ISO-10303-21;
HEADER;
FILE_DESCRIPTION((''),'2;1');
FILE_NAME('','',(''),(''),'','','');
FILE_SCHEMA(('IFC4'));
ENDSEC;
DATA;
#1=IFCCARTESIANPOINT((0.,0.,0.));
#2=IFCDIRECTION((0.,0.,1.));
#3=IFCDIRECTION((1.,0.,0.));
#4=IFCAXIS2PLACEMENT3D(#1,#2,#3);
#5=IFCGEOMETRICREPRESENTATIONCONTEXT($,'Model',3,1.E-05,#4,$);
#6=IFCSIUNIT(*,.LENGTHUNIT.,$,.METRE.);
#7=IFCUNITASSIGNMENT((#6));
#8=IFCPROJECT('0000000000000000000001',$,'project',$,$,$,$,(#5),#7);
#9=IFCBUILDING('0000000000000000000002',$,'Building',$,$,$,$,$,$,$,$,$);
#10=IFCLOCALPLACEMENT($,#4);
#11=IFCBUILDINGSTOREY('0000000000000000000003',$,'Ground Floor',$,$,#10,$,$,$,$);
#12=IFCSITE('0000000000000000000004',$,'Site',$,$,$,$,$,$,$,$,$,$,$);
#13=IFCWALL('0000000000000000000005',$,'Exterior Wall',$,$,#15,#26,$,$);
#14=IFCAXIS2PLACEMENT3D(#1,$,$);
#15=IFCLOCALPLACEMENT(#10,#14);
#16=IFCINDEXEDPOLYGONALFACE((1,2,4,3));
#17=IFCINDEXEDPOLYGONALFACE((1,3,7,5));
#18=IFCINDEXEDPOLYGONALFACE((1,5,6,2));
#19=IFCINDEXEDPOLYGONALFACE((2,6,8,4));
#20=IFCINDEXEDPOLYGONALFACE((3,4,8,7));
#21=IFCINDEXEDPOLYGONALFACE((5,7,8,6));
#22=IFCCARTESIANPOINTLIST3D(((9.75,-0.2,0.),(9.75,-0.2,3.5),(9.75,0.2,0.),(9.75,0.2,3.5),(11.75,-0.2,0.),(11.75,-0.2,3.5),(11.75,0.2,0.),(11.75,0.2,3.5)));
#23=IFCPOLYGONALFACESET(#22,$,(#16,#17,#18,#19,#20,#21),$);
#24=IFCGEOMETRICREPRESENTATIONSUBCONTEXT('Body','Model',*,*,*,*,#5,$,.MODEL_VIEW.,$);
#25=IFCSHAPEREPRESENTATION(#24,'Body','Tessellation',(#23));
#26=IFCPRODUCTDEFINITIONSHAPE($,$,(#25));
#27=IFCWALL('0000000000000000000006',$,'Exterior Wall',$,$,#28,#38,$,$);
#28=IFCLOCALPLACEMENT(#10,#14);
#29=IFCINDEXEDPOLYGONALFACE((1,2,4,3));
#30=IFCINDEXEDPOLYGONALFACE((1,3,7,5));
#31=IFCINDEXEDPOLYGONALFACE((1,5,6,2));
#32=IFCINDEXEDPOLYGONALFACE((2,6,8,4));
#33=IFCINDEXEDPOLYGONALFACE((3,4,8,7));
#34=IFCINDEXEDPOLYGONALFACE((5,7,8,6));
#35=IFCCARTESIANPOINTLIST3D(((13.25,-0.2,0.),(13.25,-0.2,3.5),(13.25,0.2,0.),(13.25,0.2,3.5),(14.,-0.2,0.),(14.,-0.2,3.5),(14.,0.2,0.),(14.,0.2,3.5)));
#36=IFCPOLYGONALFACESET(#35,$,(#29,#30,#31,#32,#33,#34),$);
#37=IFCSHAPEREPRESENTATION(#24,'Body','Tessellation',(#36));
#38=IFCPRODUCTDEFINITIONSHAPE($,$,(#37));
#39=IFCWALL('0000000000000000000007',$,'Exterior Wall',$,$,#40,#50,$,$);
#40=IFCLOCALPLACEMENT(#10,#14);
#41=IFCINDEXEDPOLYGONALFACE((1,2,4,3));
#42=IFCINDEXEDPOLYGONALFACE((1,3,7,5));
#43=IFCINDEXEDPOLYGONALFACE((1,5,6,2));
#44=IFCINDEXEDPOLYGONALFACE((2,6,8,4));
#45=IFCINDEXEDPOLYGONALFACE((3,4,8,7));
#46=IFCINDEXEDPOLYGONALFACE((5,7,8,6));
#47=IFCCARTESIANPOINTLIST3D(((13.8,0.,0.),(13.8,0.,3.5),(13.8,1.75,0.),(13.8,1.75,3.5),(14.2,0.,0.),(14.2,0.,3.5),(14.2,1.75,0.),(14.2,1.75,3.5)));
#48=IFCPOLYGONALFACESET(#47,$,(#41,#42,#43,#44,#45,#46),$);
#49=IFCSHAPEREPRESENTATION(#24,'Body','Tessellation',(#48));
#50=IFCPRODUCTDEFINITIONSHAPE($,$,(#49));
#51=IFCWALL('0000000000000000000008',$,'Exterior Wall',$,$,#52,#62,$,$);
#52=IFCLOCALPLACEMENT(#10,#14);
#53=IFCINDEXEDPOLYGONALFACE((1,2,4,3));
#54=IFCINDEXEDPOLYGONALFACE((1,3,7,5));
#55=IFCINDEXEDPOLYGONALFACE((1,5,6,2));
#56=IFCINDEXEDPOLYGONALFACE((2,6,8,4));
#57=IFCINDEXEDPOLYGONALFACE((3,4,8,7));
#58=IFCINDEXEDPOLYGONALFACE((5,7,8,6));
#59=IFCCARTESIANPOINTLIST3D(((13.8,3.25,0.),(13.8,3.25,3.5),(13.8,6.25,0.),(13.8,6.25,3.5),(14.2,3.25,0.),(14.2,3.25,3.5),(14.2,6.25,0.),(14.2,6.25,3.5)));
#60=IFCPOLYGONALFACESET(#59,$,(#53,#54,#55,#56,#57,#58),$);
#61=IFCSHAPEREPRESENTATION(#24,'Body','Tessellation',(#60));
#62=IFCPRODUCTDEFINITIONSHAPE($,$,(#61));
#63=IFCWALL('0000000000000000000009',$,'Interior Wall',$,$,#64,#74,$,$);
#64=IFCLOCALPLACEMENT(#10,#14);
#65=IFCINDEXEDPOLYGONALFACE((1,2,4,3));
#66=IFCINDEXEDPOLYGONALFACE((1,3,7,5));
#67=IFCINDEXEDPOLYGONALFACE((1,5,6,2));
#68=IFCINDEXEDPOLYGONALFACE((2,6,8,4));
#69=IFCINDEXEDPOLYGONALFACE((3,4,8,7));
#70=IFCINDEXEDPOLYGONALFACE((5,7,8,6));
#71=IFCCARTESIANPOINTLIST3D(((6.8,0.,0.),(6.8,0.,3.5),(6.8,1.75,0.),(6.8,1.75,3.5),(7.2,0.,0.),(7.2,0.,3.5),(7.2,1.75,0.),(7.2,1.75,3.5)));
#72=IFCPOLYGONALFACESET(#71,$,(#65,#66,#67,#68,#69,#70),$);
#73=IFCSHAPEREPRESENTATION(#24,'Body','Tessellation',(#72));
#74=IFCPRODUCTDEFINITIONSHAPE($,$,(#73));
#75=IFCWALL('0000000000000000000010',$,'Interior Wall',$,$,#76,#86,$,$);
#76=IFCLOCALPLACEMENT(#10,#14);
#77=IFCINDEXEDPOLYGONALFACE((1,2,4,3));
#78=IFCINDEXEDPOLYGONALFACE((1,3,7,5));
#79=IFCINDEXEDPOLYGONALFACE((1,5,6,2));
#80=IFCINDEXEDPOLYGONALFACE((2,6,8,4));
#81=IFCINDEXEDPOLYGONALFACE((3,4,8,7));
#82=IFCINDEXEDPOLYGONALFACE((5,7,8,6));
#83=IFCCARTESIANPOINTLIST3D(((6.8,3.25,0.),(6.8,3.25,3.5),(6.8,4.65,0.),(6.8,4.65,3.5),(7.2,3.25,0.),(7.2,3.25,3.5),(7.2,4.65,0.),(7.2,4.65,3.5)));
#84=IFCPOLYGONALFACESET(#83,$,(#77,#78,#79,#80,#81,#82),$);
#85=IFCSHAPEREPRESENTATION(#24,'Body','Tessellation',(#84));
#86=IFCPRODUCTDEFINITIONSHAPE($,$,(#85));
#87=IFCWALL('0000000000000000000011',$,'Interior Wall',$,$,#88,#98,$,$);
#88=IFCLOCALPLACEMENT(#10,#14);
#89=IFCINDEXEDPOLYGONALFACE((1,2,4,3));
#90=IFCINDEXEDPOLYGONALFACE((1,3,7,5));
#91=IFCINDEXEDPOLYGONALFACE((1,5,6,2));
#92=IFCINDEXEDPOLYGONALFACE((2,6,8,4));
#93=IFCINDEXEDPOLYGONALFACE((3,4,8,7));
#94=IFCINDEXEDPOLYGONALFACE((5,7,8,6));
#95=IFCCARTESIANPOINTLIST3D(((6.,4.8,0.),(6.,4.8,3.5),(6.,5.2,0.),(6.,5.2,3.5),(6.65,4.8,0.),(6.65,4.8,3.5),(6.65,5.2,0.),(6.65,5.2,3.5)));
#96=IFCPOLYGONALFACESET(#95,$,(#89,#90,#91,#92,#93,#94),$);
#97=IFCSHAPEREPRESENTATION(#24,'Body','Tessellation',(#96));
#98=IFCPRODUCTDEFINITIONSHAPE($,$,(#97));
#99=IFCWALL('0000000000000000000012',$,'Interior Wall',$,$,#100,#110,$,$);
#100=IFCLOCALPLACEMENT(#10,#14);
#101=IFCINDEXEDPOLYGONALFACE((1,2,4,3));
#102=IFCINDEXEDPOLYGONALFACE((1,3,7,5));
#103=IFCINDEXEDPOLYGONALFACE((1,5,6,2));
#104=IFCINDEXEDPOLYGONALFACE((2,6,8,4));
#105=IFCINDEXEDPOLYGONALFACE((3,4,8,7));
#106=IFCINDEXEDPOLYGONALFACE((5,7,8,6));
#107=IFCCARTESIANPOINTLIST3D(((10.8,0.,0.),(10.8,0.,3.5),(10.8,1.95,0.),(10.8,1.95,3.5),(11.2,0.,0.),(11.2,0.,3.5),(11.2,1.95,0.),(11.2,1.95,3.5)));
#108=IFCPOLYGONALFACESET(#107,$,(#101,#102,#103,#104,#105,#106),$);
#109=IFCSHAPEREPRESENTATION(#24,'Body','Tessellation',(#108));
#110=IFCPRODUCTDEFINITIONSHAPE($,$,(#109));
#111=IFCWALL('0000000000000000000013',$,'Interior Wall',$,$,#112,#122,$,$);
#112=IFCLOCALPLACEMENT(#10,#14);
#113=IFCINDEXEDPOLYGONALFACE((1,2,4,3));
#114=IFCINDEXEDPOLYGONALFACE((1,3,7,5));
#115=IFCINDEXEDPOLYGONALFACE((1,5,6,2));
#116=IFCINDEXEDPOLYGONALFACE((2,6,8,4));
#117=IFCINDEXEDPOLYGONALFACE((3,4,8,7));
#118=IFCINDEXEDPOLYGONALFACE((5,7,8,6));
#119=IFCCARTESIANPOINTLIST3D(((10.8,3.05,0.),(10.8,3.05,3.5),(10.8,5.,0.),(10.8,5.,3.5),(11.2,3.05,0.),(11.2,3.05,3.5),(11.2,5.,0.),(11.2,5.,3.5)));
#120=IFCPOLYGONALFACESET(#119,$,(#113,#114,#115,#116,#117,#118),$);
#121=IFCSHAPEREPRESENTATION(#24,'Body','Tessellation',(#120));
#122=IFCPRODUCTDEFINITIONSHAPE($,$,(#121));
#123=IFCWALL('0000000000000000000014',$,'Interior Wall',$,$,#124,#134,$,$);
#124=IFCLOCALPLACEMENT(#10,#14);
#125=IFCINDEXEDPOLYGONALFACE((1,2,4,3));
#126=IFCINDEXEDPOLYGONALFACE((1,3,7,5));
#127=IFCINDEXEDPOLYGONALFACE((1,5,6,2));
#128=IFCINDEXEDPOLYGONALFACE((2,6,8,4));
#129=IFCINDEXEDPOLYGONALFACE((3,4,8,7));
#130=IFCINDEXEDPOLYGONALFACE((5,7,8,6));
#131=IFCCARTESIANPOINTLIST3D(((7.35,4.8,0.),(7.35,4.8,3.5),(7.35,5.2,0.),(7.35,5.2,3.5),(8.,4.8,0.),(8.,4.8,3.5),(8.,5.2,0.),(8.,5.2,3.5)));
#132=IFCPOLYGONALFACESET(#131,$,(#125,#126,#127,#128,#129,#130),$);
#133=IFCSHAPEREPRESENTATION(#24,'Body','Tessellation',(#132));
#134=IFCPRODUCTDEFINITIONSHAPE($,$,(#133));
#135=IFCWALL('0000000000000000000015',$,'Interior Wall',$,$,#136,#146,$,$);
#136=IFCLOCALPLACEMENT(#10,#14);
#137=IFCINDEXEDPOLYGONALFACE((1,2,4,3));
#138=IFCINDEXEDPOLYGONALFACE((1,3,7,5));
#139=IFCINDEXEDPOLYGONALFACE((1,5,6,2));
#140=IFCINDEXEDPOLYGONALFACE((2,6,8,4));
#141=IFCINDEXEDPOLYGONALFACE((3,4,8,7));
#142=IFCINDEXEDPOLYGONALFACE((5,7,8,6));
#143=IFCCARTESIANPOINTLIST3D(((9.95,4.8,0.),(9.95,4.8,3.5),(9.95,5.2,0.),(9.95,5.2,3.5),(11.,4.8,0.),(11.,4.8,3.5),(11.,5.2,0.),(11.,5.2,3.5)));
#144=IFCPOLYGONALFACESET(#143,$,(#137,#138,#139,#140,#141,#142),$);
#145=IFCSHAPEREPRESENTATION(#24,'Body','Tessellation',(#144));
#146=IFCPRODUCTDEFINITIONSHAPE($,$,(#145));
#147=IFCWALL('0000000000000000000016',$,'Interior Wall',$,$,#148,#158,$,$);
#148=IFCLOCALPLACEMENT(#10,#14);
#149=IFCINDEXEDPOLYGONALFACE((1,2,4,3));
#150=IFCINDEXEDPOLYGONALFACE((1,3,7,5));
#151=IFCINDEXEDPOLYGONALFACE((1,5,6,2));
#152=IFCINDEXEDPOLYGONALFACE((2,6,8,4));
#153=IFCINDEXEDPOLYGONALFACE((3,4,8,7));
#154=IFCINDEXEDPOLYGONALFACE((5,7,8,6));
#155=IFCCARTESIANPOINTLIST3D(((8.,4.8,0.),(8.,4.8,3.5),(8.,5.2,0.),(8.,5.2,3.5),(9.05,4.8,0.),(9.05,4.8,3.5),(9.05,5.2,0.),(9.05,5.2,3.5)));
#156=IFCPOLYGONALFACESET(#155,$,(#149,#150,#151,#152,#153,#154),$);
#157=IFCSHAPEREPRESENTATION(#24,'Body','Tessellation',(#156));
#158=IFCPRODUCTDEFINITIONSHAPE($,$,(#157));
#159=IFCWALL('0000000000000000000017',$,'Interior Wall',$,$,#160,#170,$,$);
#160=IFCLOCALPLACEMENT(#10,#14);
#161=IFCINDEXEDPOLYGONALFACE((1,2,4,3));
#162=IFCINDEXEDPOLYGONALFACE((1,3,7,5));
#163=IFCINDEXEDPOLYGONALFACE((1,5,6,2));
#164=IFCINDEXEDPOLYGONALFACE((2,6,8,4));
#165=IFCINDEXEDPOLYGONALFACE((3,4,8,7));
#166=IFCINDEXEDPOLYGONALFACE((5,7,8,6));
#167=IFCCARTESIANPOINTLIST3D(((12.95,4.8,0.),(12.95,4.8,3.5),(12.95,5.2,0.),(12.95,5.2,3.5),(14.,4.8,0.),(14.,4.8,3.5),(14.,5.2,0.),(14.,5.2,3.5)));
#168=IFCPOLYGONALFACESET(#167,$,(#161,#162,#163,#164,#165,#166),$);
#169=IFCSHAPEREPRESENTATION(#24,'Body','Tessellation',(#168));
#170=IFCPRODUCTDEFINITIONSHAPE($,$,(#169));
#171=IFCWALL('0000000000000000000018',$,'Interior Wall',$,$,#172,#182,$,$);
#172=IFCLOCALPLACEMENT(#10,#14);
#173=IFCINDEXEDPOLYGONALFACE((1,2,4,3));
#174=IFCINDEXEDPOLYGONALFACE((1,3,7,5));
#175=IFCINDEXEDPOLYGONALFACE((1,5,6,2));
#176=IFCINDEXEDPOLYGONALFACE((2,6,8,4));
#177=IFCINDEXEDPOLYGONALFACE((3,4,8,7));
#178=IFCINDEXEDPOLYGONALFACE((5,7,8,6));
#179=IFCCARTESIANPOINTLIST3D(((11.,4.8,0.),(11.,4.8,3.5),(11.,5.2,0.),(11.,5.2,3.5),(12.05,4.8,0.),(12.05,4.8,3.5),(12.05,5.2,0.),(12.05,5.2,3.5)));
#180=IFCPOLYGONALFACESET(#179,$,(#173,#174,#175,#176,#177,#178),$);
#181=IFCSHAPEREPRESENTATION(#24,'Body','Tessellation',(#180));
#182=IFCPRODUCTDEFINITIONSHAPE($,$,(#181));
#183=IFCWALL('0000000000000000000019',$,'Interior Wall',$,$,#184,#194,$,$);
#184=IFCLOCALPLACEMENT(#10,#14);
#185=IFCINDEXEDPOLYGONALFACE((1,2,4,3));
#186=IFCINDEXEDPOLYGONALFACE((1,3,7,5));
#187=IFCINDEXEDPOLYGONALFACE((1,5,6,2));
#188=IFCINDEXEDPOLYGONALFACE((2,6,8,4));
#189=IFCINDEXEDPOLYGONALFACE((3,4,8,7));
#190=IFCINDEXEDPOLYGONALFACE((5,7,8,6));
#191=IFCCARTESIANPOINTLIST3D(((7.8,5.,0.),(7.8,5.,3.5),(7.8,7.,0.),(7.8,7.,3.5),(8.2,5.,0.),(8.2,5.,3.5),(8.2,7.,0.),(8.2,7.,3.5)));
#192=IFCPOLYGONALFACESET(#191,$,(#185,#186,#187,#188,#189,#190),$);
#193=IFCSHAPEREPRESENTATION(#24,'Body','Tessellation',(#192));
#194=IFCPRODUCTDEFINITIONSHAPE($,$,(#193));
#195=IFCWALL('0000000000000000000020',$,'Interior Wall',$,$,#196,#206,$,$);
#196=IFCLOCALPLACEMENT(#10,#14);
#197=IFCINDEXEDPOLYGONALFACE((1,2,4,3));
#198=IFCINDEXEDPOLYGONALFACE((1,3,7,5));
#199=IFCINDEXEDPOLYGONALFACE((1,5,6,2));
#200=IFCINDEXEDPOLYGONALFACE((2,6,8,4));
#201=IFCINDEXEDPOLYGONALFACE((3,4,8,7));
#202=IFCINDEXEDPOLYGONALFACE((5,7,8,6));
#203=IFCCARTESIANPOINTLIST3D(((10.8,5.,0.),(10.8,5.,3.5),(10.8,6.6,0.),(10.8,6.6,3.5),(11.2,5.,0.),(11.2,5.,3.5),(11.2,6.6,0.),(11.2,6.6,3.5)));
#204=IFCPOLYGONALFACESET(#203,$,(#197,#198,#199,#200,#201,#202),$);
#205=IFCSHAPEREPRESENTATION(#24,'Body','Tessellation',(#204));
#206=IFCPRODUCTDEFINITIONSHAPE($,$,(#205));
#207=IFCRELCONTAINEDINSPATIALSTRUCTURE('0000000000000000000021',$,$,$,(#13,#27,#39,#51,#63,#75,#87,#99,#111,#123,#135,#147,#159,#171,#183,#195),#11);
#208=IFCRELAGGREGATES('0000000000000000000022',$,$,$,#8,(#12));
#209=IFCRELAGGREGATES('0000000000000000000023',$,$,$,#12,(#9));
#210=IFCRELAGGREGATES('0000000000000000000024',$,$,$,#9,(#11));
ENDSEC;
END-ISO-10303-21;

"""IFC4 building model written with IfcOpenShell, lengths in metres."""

from ifc_helpers import new_model, si_unit, frame, origin_with_axes, place, context, subcontext, project, spatial, indexed_curve, outline, extrude, element, save


model = new_model("IFC4")

# Units and contexts
model_context = context("Model", 3, precision=1e-05, world=origin_with_axes())
body_context = subcontext(model_context, "Body", "Model", "MODEL_VIEW")
ifc_project = project(units=[si_unit("LENGTHUNIT", "METRE")], contexts=[model_context])

# Site, building, storey
site = spatial("IfcSite", under=ifc_project, Name="Site")
building = spatial("IfcBuilding", under=site, Name="Building")
storey_placement = place(None, origin_with_axes())
storey = spatial("IfcBuildingStorey", under=building, at=storey_placement, Name="Ground Floor")

# Walls
wall_1_placement = place(storey_placement, frame((9.75, 0.0, 0.0), z_axis=(0.0, 0.0, 1.0), x_axis=(1.0, 0.0, 0.0)))
element("IfcWall", 1, at=wall_1_placement, inside=storey, Name="Exterior Wall", context=body_context, shape_type="SweptSolid", body=[
    extrude(outline(indexed_curve([(0.0, 0.0), (0.0, 0.4), (2.0, 0.4), (2.0, 0.0), (0.0, 0.0)], self_intersect=False)), frame((0.0, -0.2, 0.0), z_axis=(0.0, 0.0, 1.0), x_axis=(1.0, 0.0, 0.0)), (0.0, 0.0, 1.0), 3.5),
])
wall_2_placement = place(storey_placement, frame((13.25, 0.0, 0.0), z_axis=(0.0, 0.0, 1.0), x_axis=(1.0, 0.0, 0.0)))
element("IfcWall", 2, at=wall_2_placement, inside=storey, Name="Exterior Wall", context=body_context, shape_type="SweptSolid", body=[
    extrude(outline(indexed_curve([(0.0, 0.0), (0.0, 0.4), (0.75, 0.4), (0.75, 0.0), (0.0, 0.0)], self_intersect=False)), frame((0.0, -0.2, 0.0), z_axis=(0.0, 0.0, 1.0), x_axis=(1.0, 0.0, 0.0)), (0.0, 0.0, 1.0), 3.5),
])
wall_3_placement = place(storey_placement, frame((14.0, 0.0, 0.0), z_axis=(0.0, 0.0, 1.0), x_axis=(0.0, 1.0, 0.0)))
element("IfcWall", 3, at=wall_3_placement, inside=storey, Name="Exterior Wall", context=body_context, shape_type="SweptSolid", body=[
    extrude(outline(indexed_curve([(0.0, 0.0), (0.0, 0.4), (1.75, 0.4), (1.75, 0.0), (0.0, 0.0)], self_intersect=False)), frame((0.0, -0.2, 0.0), z_axis=(0.0, 0.0, 1.0), x_axis=(1.0, 0.0, 0.0)), (0.0, 0.0, 1.0), 3.5),
])
wall_4_placement = place(storey_placement, frame((14.0, 3.25, 0.0), z_axis=(0.0, 0.0, 1.0), x_axis=(0.0, 1.0, 0.0)))
element("IfcWall", 4, at=wall_4_placement, inside=storey, Name="Exterior Wall", context=body_context, shape_type="SweptSolid", body=[
    extrude(outline(indexed_curve([(0.0, 0.0), (0.0, 0.4), (3.0, 0.4), (3.0, 0.0), (0.0, 0.0)], self_intersect=False)), frame((0.0, -0.2, 0.0), z_axis=(0.0, 0.0, 1.0), x_axis=(1.0, 0.0, 0.0)), (0.0, 0.0, 1.0), 3.5),
])
wall_5_placement = place(storey_placement, frame((7.0, 0.0, 0.0), z_axis=(0.0, 0.0, 1.0), x_axis=(0.0, 1.0, 0.0)))
element("IfcWall", 5, at=wall_5_placement, inside=storey, Name="Interior Wall", context=body_context, shape_type="SweptSolid", body=[
    extrude(outline(indexed_curve([(0.0, 0.0), (0.0, 0.4), (1.75, 0.4), (1.75, 0.0), (0.0, 0.0)], self_intersect=False)), frame((0.0, -0.2, 0.0), z_axis=(0.0, 0.0, 1.0), x_axis=(1.0, 0.0, 0.0)), (0.0, 0.0, 1.0), 3.5),
])
wall_6_placement = place(storey_placement, frame((7.0, 3.25, 0.0), z_axis=(0.0, 0.0, 1.0), x_axis=(0.0, 1.0, 0.0)))
element("IfcWall", 6, at=wall_6_placement, inside=storey, Name="Interior Wall", context=body_context, shape_type="SweptSolid", body=[
    extrude(outline(indexed_curve([(0.0, 0.0), (0.0, 0.4), (1.4, 0.4), (1.4, 0.0), (0.0, 0.0)], self_intersect=False)), frame((0.0, -0.2, 0.0), z_axis=(0.0, 0.0, 1.0), x_axis=(1.0, 0.0, 0.0)), (0.0, 0.0, 1.0), 3.5),
])
wall_7_placement = place(storey_placement, frame((6.65, 5.0, 0.0), z_axis=(0.0, 0.0, 1.0), x_axis=(-1.0, 0.0, 0.0)))
element("IfcWall", 7, at=wall_7_placement, inside=storey, Name="Interior Wall", context=body_context, shape_type="SweptSolid", body=[
    extrude(outline(indexed_curve([(0.0, 0.0), (0.0, 0.4), (0.65, 0.4), (0.65, 0.0), (0.0, 0.0)], self_intersect=False)), frame((0.0, -0.2, 0.0), z_axis=(0.0, 0.0, 1.0), x_axis=(1.0, 0.0, 0.0)), (0.0, 0.0, 1.0), 3.5),
])
wall_8_placement = place(storey_placement, frame((11.0, 0.0, 0.0), z_axis=(0.0, 0.0, 1.0), x_axis=(0.0, 1.0, 0.0)))
element("IfcWall", 8, at=wall_8_placement, inside=storey, Name="Interior Wall", context=body_context, shape_type="SweptSolid", body=[
    extrude(outline(indexed_curve([(0.0, 0.0), (0.0, 0.4), (1.95, 0.4), (1.95, 0.0), (0.0, 0.0)], self_intersect=False)), frame((0.0, -0.2, 0.0), z_axis=(0.0, 0.0, 1.0), x_axis=(1.0, 0.0, 0.0)), (0.0, 0.0, 1.0), 3.5),
])
wall_9_placement = place(storey_placement, frame((11.0, 3.05, 0.0), z_axis=(0.0, 0.0, 1.0), x_axis=(0.0, 1.0, 0.0)))
element("IfcWall", 9, at=wall_9_placement, inside=storey, Name="Interior Wall", context=body_context, shape_type="SweptSolid", body=[
    extrude(outline(indexed_curve([(0.0, 0.0), (0.0, 0.4), (1.95, 0.4), (1.95, 0.0), (0.0, 0.0)], self_intersect=False)), frame((0.0, -0.2, 0.0), z_axis=(0.0, 0.0, 1.0), x_axis=(1.0, 0.0, 0.0)), (0.0, 0.0, 1.0), 3.5),
])
wall_10_placement = place(storey_placement, frame((8.0, 5.0, 0.0), z_axis=(0.0, 0.0, 1.0), x_axis=(-1.0, 0.0, 0.0)))
element("IfcWall", 10, at=wall_10_placement, inside=storey, Name="Interior Wall", context=body_context, shape_type="SweptSolid", body=[
    extrude(outline(indexed_curve([(0.0, 0.0), (0.0, 0.4), (0.65, 0.4), (0.65, 0.0), (0.0, 0.0)], self_intersect=False)), frame((0.0, -0.2, 0.0), z_axis=(0.0, 0.0, 1.0), x_axis=(1.0, 0.0, 0.0)), (0.0, 0.0, 1.0), 3.5),
])
for number, where, z_axis, x_axis, name in (
    (11, (11.0, 5.0, 0.0), (0.0, 0.0, 1.0), (-1.0, 0.0, 0.0), "Interior Wall"),
    (12, (9.05, 5.0, 0.0), (0.0, 0.0, 1.0), (-1.0, 0.0, 0.0), "Interior Wall"),
    (13, (14.0, 5.0, 0.0), (0.0, 0.0, 1.0), (-1.0, 0.0, 0.0), "Interior Wall"),
    (14, (12.05, 5.0, 0.0), (0.0, 0.0, 1.0), (-1.0, 0.0, 0.0), "Interior Wall"),
):
    element("IfcWall", number, at=place(storey_placement, frame(where, z_axis=z_axis, x_axis=x_axis)), inside=storey, Name=name, context=body_context, shape_type="SweptSolid", body=[
        extrude(outline(indexed_curve([(0.0, 0.0), (0.0, 0.4), (1.05, 0.4), (1.05, 0.0), (0.0, 0.0)], self_intersect=False)), frame((0.0, -0.2, 0.0), z_axis=(0.0, 0.0, 1.0), x_axis=(1.0, 0.0, 0.0)), (0.0, 0.0, 1.0), 3.5),
    ])
wall_11_placement = place(storey_placement, frame((8.0, 5.0, 0.0), z_axis=(0.0, 0.0, 1.0), x_axis=(0.0, 1.0, 0.0)))
element("IfcWall", 15, at=wall_11_placement, inside=storey, Name="Interior Wall", context=body_context, shape_type="SweptSolid", body=[
    extrude(outline(indexed_curve([(0.0, 0.0), (0.0, 0.4), (2.0, 0.4), (2.0, 0.0), (0.0, 0.0)], self_intersect=False)), frame((0.0, -0.2, 0.0), z_axis=(0.0, 0.0, 1.0), x_axis=(1.0, 0.0, 0.0)), (0.0, 0.0, 1.0), 3.5),
])
wall_12_placement = place(storey_placement, frame((11.0, 5.0, 0.0), z_axis=(0.0, 0.0, 1.0), x_axis=(0.0, 1.0, 0.0)))
element("IfcWall", 16, at=wall_12_placement, inside=storey, Name="Interior Wall", context=body_context, shape_type="SweptSolid", body=[
    extrude(outline(indexed_curve([(0.0, 0.0), (0.0, 0.4), (1.6, 0.4), (1.6, 0.0), (0.0, 0.0)], self_intersect=False)), frame((0.0, -0.2, 0.0), z_axis=(0.0, 0.0, 1.0), x_axis=(1.0, 0.0, 0.0)), (0.0, 0.0, 1.0), 3.5),
])

save(model, "model.ifc")
